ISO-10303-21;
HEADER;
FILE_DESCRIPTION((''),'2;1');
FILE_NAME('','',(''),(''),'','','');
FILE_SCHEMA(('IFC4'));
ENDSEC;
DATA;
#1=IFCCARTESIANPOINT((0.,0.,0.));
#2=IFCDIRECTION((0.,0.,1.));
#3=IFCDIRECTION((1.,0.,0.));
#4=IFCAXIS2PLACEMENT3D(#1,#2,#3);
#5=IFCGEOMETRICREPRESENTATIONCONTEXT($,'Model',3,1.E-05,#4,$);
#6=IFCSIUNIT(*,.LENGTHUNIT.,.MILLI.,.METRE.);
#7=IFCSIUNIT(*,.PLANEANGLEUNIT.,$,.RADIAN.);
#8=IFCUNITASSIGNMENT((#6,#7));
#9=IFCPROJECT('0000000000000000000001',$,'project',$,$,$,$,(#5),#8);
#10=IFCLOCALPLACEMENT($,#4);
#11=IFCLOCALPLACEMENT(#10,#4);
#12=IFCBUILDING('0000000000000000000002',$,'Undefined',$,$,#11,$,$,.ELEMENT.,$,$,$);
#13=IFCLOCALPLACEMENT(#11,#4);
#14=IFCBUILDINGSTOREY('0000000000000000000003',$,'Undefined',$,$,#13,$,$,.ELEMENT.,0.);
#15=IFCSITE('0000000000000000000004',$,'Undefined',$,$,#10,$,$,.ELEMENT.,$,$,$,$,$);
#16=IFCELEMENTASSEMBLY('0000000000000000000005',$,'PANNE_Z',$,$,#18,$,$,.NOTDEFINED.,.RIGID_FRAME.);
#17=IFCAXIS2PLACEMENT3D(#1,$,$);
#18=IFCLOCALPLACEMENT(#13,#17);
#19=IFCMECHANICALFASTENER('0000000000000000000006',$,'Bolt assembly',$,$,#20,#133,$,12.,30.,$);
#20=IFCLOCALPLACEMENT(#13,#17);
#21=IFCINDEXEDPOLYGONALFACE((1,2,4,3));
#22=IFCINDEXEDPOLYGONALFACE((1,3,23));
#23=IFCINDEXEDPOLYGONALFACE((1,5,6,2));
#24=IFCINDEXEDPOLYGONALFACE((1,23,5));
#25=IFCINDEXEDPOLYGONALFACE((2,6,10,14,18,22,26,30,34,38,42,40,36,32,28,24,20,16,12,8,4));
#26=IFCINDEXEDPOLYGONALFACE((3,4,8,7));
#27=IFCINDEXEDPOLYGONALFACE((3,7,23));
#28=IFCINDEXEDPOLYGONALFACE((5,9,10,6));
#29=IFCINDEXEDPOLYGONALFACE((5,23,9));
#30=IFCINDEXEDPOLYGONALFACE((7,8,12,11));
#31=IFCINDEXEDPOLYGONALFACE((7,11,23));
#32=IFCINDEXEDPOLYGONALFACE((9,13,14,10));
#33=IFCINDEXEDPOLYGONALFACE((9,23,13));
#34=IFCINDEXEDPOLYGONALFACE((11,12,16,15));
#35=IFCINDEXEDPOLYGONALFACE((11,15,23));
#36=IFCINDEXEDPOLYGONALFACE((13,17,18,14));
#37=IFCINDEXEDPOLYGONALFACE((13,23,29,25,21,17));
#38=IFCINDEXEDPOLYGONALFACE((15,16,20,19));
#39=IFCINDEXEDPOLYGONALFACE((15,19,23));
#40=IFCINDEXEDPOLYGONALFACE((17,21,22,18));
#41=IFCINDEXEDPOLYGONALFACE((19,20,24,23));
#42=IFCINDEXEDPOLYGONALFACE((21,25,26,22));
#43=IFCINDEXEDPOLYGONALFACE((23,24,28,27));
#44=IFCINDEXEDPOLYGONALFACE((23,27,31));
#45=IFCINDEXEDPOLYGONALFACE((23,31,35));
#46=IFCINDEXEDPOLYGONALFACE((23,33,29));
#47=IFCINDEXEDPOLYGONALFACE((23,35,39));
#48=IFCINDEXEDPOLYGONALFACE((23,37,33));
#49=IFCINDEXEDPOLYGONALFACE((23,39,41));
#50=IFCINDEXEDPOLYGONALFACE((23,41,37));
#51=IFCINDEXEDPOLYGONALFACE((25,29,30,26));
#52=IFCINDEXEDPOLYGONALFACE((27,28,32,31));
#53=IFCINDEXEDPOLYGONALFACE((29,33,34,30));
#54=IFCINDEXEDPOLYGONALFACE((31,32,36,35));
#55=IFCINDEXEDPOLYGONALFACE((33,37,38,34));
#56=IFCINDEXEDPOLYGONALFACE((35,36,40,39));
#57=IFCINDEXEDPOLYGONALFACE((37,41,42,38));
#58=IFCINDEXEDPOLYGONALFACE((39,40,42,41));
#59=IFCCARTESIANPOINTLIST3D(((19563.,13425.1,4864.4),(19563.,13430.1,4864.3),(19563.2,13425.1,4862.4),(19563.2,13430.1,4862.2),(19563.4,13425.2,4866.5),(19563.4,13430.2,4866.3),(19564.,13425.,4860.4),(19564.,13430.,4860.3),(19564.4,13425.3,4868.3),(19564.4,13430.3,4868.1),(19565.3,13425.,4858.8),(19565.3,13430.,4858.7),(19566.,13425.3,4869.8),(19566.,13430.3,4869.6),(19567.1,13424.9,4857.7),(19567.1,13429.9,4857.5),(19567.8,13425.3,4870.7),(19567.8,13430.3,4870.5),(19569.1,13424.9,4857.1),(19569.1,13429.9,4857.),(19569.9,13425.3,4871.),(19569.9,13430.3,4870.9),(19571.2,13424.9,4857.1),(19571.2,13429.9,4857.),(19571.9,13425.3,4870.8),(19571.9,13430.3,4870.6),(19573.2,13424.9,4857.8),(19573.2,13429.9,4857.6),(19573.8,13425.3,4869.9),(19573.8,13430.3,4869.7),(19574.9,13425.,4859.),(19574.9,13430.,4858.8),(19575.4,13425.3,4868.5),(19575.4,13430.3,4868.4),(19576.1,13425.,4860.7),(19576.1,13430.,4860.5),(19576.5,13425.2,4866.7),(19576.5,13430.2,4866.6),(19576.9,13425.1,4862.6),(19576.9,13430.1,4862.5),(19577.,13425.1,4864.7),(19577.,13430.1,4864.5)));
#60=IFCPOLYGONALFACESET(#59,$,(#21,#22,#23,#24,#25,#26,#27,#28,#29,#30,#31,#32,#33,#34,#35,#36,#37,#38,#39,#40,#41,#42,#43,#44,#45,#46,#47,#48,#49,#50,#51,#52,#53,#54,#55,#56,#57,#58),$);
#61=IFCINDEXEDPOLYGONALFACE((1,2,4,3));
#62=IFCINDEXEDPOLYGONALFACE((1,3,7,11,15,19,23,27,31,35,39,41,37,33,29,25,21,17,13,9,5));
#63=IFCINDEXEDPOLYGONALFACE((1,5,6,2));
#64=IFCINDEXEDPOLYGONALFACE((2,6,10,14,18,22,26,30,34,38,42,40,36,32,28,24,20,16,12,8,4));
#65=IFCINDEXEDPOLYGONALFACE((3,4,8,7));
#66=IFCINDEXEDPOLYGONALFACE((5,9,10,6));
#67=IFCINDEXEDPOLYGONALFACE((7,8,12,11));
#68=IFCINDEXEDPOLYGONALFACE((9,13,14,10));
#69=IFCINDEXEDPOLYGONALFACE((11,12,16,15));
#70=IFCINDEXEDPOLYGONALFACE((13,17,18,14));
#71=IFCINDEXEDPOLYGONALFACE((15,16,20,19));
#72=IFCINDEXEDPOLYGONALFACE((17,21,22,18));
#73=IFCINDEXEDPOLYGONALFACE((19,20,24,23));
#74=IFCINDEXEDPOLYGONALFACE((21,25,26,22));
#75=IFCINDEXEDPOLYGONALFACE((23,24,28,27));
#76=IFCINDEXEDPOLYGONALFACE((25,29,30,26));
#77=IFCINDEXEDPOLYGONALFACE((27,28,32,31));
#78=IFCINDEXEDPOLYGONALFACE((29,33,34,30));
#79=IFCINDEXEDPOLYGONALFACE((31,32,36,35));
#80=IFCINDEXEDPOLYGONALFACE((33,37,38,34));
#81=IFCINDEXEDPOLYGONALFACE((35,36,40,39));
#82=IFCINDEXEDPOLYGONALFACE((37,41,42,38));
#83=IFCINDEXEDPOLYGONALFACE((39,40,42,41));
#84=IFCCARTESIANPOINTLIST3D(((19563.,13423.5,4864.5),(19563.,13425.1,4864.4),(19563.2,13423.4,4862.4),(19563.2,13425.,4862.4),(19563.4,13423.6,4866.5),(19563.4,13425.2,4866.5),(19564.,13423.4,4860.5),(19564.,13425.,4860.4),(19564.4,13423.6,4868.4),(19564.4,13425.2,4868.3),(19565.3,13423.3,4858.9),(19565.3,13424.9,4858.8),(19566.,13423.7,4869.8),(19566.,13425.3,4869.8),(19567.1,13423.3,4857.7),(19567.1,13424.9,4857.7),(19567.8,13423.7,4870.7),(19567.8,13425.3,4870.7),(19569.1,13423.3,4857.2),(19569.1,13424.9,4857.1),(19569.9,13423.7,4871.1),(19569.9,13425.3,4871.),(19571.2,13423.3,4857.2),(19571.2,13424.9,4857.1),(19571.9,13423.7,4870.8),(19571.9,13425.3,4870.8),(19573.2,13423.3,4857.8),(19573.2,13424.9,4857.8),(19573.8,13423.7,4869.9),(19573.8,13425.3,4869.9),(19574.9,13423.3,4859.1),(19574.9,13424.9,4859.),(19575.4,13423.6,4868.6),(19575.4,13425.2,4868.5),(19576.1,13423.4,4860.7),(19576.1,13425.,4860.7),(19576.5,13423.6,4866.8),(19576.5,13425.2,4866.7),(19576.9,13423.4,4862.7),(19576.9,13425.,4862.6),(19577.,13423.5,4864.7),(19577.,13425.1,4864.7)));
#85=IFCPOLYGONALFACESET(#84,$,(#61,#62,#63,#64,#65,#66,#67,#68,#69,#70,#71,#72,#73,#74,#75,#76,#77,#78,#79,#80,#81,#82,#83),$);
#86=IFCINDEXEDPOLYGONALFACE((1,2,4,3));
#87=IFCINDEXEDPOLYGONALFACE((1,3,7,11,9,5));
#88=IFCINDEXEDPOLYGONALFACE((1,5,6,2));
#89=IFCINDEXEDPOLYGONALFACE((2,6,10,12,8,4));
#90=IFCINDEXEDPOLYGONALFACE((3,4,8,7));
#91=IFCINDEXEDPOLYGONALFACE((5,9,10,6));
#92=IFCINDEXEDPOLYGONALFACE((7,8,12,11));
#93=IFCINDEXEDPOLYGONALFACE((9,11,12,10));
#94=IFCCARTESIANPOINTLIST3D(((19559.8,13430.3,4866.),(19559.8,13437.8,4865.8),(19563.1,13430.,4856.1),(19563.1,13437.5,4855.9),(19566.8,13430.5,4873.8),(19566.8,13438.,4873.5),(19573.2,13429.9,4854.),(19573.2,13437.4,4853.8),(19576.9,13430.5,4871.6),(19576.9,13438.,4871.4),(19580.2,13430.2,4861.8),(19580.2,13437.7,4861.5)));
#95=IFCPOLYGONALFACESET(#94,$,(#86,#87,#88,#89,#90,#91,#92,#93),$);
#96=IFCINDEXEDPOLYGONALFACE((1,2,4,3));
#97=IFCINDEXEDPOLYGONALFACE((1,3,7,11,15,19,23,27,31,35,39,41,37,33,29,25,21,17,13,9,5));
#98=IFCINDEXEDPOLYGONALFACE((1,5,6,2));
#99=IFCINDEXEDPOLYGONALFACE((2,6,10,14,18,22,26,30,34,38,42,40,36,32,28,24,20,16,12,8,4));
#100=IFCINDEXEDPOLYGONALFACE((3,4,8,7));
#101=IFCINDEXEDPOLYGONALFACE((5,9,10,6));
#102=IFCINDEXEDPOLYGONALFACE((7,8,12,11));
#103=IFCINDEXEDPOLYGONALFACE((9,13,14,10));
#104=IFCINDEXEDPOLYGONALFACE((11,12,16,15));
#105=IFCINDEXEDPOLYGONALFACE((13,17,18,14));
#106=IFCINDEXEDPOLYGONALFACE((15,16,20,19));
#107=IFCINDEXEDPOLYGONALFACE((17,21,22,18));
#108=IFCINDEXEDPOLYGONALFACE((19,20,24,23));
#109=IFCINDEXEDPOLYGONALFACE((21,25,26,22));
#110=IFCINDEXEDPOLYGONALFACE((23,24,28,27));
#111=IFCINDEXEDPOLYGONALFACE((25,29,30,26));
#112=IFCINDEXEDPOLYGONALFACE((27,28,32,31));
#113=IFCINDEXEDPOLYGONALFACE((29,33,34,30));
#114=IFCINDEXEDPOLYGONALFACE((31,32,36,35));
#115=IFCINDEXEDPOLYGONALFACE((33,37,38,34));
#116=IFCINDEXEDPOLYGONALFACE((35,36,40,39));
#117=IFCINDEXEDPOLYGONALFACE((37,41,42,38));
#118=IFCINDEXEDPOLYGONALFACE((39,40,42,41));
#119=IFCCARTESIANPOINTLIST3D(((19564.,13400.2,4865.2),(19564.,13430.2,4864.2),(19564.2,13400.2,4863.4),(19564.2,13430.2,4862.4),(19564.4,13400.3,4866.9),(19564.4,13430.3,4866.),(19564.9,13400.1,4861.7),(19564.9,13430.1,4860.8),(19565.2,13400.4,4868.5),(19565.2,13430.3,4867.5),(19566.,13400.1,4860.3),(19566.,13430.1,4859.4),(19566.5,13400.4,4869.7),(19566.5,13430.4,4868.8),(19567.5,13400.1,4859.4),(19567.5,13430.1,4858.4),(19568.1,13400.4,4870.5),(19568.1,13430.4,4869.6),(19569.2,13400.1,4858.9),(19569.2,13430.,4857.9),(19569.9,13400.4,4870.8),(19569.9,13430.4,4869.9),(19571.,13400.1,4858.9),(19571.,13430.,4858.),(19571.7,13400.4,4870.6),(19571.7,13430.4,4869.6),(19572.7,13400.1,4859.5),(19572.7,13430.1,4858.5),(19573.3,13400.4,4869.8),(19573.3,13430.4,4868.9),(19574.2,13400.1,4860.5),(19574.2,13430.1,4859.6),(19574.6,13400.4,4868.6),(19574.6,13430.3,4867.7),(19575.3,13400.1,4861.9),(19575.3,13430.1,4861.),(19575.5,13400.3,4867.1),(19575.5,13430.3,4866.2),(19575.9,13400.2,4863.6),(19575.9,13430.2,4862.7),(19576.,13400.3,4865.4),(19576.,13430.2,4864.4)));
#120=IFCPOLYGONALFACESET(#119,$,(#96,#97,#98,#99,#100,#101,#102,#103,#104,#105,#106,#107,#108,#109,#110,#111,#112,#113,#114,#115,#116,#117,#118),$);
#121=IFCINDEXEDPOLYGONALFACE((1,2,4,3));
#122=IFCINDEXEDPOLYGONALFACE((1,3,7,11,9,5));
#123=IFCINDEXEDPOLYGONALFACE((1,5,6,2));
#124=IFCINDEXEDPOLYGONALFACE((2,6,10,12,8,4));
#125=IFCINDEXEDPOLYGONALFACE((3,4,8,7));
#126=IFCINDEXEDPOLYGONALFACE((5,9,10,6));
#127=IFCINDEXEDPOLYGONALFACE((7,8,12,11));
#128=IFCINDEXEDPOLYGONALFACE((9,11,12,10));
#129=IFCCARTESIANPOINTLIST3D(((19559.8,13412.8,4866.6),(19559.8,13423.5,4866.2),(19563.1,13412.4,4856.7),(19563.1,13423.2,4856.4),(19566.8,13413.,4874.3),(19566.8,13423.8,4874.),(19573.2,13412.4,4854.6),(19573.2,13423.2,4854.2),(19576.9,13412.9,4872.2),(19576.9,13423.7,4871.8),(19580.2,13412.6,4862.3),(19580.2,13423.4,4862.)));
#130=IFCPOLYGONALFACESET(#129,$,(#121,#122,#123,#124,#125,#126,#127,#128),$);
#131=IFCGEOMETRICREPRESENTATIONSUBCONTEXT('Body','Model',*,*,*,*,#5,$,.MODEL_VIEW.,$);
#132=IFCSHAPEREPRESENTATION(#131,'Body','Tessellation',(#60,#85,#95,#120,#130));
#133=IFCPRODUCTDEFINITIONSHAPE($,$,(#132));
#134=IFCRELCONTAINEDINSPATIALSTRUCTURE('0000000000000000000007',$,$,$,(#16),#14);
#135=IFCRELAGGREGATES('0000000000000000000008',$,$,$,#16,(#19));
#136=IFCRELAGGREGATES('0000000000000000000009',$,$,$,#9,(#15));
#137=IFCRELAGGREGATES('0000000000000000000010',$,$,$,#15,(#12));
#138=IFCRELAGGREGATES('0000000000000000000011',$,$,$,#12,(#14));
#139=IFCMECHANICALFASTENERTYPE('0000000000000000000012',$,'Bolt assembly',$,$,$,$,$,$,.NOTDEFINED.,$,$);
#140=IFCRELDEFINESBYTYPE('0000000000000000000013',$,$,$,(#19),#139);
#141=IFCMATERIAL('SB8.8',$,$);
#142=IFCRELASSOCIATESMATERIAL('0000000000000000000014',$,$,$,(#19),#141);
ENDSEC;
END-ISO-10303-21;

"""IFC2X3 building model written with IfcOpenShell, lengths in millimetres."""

from ifc_helpers import new_model, si_unit, frame, origin_with_axes, origin_2d_with_axis, place, context, subcontext, project, spatial, polyline, circle, outline, extrude, source, transform, mapped, material, type_object, element, aggregate, save


model = new_model("IFC2X3")

# Units and contexts
model_context = context("Model", 3, precision=1e-05, world=origin_with_axes())
body_context = subcontext(model_context, "Body", "Model", "MODEL_VIEW")
ifc_project = project(units=[si_unit("LENGTHUNIT", "METRE", prefix="MILLI"), si_unit("PLANEANGLEUNIT", "RADIAN")], contexts=[model_context])

# Site, building, storey
site_placement = place(None, origin_with_axes())
site = spatial("IfcSite", under=ifc_project, at=site_placement, Name="Undefined", CompositionType="ELEMENT")
building_placement = place(site_placement, origin_with_axes())
building = spatial("IfcBuilding", under=site, at=building_placement, Name="Undefined", CompositionType="ELEMENT")
storey_placement = place(building_placement, origin_with_axes())
storey = spatial("IfcBuildingStorey", under=building, at=storey_placement, Name="Undefined", CompositionType="ELEMENT", Elevation=0.0)

# Shared definitions
ifc_material_1 = material(Name="SB8.8")
mechanical_fastener_type = type_object("IfcMechanicalFastenerType", Name="Bolt assembly")

# Element assembly, mechanical fastener
assembly_1_placement = place(storey_placement, origin_with_axes())
assembly_1 = element("IfcElementAssembly", 1, at=assembly_1_placement, inside=storey, Name="PANNE_Z", AssemblyPlace="NOTDEFINED", PredefinedType="RIGID_FRAME")
shared_shape_1 = source(origin_with_axes(), body_context, "Body", "SweptSolid", [
    extrude(circle(Radius=7.0, at=origin_2d_with_axis()), frame((0.0, -4.9, 0.0), z_axis=(0.0, 1.0, 0.0), x_axis=(1.0, 0.0, 0.0)), (0.0, 0.0, 1.0), 5.0),
    extrude(circle(Radius=7.0, at=origin_2d_with_axis()), frame((0.0, 0.1, 0.0), z_axis=(0.0, 1.0, 0.0), x_axis=(1.0, 0.0, 0.0)), (0.0, 0.0, 1.0), 1.6),
    extrude(outline(polyline([(10.4, 0.0), (5.2, 9.0), (-5.2, 9.0), (-10.4, 0.0), (-5.2, -9.0), (5.2, -9.0), (10.4, 0.0)])), frame((0.0, -12.5, 0.0), z_axis=(0.0, 1.0, 0.0), x_axis=(1.0, 0.0, 0.0)), (0.0, 0.0, 1.0), 7.5),
    extrude(circle(Radius=6.0, at=origin_2d_with_axis()), frame((0.0, -5.0, 0.0), z_axis=(0.0, 1.0, 0.0), x_axis=(1.0, 0.0, 0.0)), (0.0, 0.0, 1.0), 30.0),
    extrude(outline(polyline([(10.4, 0.0), (5.2, 9.0), (-5.2, 9.0), (-10.4, 0.0), (-5.2, -9.0), (5.2, -9.0), (10.4, 0.0)])), frame((0.0, 1.7, 0.0), z_axis=(0.0, 1.0, 0.0), x_axis=(1.0, 0.0, 0.0)), (0.0, 0.0, 1.0), 10.8),
])
mechanical_fastener_1_placement = place(assembly_1_placement, frame((19570.0, 13425.2, 4864.0), z_axis=(-0.745405, 0.020656, 0.666292), x_axis=(-0.666612, -0.023097, -0.745047)))
mechanical_fastener_1 = element("IfcMechanicalFastener", 2, at=mechanical_fastener_1_placement, type_object=mechanical_fastener_type, material=ifc_material_1, Name="Bolt assembly", NominalDiameter=12.0, NominalLength=30.0, context=body_context, shape_type="MappedRepresentation", body=[
    mapped(shared_shape_1, transform((0.0, 0.0, 0.0))),
])
aggregate(assembly_1, [mechanical_fastener_1])

save(model, "model.ifc")
